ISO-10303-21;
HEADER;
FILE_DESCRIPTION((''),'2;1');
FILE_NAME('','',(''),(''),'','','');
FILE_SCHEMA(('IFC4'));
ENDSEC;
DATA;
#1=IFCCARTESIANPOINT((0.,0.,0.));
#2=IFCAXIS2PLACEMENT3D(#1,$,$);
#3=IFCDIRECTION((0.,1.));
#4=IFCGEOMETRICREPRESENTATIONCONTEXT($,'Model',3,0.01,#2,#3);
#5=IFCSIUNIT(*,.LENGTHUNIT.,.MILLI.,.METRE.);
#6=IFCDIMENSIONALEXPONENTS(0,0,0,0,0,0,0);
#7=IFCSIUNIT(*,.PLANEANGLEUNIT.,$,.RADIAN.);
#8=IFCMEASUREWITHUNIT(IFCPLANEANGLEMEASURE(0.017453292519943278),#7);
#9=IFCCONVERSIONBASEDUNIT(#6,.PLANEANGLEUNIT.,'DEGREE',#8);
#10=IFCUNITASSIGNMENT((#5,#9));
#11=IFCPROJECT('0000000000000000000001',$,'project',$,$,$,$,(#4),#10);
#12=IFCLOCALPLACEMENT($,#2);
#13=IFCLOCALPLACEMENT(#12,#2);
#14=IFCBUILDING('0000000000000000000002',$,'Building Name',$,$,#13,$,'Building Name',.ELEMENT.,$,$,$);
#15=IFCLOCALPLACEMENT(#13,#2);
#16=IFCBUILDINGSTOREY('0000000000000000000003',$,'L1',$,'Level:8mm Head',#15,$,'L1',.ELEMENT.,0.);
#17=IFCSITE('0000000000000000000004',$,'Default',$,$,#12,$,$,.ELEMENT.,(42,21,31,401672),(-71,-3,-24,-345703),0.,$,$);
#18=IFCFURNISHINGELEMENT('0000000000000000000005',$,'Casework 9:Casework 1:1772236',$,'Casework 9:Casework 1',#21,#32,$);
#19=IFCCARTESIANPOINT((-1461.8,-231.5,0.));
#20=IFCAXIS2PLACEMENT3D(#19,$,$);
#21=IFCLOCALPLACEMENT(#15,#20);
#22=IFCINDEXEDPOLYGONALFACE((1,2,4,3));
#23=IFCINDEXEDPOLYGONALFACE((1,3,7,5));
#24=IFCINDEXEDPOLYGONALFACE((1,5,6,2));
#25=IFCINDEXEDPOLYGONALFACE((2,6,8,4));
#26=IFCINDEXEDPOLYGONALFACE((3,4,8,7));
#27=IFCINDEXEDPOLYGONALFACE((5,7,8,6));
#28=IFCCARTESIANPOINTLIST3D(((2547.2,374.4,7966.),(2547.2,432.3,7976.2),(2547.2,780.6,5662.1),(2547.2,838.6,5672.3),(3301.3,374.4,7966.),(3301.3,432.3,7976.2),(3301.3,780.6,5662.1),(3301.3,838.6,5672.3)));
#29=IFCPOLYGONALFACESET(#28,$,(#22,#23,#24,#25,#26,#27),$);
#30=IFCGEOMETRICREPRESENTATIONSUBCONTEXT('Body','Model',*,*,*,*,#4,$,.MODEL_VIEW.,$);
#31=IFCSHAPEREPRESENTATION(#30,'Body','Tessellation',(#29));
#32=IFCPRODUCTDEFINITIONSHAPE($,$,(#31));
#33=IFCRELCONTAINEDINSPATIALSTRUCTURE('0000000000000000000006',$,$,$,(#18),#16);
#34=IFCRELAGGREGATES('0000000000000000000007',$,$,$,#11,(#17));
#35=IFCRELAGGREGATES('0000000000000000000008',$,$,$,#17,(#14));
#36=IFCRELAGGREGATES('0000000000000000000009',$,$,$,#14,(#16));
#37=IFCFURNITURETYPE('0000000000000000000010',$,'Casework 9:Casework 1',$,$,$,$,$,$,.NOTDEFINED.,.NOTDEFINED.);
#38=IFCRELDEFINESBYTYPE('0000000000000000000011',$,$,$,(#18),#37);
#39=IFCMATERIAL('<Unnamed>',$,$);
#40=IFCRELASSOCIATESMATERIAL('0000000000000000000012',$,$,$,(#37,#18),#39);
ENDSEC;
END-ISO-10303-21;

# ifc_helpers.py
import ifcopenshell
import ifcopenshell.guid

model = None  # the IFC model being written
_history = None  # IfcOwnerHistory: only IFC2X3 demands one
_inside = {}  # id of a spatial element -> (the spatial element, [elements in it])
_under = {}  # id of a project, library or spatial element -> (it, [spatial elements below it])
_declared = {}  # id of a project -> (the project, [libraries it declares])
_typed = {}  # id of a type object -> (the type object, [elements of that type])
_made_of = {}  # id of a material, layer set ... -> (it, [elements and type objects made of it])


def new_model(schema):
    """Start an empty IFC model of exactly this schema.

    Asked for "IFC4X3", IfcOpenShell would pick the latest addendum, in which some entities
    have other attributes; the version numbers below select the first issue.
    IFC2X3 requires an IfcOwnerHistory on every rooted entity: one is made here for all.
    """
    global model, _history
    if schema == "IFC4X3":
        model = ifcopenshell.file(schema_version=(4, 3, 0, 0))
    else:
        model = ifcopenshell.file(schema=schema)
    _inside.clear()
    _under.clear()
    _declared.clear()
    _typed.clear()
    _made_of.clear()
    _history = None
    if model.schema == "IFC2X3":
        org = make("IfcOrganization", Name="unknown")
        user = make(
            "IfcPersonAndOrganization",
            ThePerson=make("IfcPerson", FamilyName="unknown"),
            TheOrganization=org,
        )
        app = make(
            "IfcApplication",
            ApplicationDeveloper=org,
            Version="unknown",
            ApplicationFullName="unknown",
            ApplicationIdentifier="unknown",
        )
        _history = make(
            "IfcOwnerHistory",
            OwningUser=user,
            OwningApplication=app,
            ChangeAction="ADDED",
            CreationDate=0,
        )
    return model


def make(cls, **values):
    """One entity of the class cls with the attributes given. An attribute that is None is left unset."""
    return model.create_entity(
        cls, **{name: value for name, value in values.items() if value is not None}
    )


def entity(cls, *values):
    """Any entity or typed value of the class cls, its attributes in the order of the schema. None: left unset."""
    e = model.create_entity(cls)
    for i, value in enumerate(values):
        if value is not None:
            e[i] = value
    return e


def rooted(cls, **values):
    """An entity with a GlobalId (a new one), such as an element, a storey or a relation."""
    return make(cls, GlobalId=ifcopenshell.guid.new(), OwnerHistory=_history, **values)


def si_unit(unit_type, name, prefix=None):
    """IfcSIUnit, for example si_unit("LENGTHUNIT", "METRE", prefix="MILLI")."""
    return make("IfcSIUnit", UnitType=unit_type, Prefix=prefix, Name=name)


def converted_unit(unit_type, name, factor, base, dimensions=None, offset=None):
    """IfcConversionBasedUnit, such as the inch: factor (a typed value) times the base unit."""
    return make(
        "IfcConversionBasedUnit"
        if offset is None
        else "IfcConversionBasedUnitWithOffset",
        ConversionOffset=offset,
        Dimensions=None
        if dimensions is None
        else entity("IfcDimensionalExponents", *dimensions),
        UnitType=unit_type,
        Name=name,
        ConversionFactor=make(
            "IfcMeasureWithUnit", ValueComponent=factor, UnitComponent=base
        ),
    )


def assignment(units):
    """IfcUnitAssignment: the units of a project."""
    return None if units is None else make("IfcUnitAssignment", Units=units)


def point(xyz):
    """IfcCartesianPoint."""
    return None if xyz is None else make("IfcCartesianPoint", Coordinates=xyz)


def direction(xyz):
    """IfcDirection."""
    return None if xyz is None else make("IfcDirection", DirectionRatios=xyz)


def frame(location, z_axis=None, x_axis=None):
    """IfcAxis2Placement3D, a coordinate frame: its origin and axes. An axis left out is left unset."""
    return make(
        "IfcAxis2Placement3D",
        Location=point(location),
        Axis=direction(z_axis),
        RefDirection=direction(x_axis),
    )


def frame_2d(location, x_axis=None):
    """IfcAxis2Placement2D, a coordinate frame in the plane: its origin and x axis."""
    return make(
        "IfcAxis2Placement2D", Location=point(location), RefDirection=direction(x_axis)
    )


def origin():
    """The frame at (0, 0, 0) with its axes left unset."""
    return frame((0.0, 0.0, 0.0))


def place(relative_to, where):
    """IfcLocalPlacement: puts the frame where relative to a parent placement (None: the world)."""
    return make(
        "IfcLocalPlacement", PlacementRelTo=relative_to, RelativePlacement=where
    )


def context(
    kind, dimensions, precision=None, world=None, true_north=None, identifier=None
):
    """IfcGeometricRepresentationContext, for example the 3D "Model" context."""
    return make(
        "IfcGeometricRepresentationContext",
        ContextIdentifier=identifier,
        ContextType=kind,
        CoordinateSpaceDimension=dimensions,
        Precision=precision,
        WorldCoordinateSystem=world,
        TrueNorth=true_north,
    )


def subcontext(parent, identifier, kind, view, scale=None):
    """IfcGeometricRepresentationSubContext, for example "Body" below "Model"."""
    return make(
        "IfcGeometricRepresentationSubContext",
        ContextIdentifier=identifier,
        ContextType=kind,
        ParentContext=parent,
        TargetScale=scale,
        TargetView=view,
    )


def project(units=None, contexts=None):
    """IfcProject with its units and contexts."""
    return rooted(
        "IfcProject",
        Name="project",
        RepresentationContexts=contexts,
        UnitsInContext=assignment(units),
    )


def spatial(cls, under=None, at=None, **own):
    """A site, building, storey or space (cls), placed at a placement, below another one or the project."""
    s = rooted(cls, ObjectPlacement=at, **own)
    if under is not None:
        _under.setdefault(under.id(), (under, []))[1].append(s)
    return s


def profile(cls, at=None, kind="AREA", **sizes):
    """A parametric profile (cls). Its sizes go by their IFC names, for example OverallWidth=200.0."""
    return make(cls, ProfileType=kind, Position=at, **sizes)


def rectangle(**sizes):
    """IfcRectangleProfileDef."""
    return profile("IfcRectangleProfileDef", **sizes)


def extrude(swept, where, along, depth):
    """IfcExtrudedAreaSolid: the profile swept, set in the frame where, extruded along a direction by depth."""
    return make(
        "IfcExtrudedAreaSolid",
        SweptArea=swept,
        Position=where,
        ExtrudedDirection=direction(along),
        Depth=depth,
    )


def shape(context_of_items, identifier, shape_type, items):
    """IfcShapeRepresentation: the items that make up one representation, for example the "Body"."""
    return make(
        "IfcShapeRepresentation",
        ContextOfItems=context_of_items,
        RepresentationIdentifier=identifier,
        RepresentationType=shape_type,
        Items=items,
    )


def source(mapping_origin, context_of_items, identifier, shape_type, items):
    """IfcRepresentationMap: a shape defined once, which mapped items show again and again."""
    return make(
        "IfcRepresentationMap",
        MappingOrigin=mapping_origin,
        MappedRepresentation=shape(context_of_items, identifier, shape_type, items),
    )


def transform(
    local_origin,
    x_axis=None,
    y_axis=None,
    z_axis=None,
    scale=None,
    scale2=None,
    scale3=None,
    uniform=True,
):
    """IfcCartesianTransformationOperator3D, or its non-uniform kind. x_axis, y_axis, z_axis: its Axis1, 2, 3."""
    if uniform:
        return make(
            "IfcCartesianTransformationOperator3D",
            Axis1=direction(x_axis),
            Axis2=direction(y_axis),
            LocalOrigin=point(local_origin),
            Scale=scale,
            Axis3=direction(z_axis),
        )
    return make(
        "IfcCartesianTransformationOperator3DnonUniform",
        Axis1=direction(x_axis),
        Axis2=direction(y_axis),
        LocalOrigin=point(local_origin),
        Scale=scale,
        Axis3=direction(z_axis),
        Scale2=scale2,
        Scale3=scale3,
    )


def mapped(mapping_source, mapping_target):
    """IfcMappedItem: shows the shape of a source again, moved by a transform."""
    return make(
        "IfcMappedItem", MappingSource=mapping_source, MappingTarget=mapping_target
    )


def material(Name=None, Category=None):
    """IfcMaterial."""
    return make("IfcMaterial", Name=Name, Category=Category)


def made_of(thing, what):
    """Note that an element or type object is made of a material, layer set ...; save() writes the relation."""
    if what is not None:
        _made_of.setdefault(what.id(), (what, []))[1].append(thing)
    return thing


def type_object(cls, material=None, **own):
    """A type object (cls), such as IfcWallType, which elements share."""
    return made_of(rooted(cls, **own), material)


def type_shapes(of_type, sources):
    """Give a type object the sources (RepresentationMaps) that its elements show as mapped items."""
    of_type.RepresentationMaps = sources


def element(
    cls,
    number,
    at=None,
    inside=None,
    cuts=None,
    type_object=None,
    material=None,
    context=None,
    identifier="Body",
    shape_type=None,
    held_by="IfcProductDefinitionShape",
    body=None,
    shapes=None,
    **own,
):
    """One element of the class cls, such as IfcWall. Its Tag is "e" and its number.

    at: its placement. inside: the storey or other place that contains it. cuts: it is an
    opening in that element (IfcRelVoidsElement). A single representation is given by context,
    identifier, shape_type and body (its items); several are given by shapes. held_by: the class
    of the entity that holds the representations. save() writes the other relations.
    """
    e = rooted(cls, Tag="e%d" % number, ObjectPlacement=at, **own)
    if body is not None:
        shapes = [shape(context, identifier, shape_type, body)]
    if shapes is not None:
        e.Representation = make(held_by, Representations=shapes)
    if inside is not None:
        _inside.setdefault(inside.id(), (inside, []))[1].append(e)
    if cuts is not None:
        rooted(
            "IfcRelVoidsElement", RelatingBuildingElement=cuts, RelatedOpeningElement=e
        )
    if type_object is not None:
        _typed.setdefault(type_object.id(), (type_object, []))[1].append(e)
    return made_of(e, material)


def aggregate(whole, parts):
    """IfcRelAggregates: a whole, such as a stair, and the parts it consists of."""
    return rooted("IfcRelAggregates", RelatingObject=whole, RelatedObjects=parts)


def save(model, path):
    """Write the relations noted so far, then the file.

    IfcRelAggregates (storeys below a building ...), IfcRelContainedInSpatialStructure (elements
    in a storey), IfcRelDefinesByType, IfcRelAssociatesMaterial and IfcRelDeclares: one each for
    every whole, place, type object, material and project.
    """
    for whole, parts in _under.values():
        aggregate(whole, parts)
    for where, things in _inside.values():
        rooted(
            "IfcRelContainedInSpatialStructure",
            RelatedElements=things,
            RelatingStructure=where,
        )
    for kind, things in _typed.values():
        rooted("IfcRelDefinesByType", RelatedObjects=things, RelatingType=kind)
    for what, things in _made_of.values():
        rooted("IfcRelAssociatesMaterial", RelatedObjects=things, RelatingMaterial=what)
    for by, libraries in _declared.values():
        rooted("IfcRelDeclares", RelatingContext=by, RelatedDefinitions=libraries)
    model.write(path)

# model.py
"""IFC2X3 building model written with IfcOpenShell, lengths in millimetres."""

from ifc_helpers import new_model, entity, si_unit, converted_unit, direction, frame, frame_2d, origin, place, context, subcontext, project, spatial, rectangle, extrude, source, transform, mapped, material, type_object, type_shapes, element, save


model = new_model("IFC2X3")

# Units and contexts
model_context = context("Model", 3, precision=0.01, world=origin(), true_north=direction((0.0, 1.0)))
body_context = subcontext(model_context, "Body", "Model", "MODEL_VIEW")
ifc_project = project(units=[si_unit("LENGTHUNIT", "METRE", prefix="MILLI"), converted_unit("PLANEANGLEUNIT", "DEGREE", entity("IfcPlaneAngleMeasure", 0.017453292519943278), si_unit("PLANEANGLEUNIT", "RADIAN"), dimensions=[0, 0, 0, 0, 0, 0, 0])], contexts=[model_context])

# Site, building, storey
site_placement = place(None, origin())
site = spatial("IfcSite", under=ifc_project, at=site_placement, Name="Default", CompositionType="ELEMENT", RefLatitude=(42, 21, 31, 401672), RefLongitude=(-71, -3, -24, -345703), RefElevation=0.0)
building_placement = place(site_placement, origin())
building = spatial("IfcBuilding", under=site, at=building_placement, Name="Building Name", LongName="Building Name", CompositionType="ELEMENT")
storey_placement = place(building_placement, origin())
storey = spatial("IfcBuildingStorey", under=building, at=storey_placement, Name="L1", ObjectType="Level:8mm Head", LongName="L1", CompositionType="ELEMENT", Elevation=0.0)

# Shared definitions
ifc_material_1 = material(Name="<Unnamed>")

# Furnishing element
furniture_type_1 = type_object("IfcFurnitureType", Name="Casework 9:Casework 1", AssemblyPlace="NOTDEFINED", material=ifc_material_1)
shared_shape_1 = source(origin(), body_context, "Body", "SweptSolid", [
    extrude(rectangle(XDim=58.9, YDim=754.1, at=frame_2d((0.0, 0.0), x_axis=(1.0, 0.0))), frame((2924.3, 809.6, 5667.2), z_axis=(0.0, -0.173648, 0.984808), x_axis=(0.0, -0.984808, -0.173648)), (0.0, 0.0, 1.0), 2339.4),
])
type_shapes(furniture_type_1, [shared_shape_1])
furnishing_1_placement = place(storey_placement, frame((-1461.8, -231.5, 0.0)))
element("IfcFurnishingElement", 1, at=furnishing_1_placement, inside=storey, type_object=furniture_type_1, material=ifc_material_1, Name="Casework 9:Casework 1:1772236", ObjectType="Casework 9:Casework 1", context=body_context, shape_type="MappedRepresentation", body=[
    mapped(shared_shape_1, transform((0.0, 0.0, 0.0), scale=1.0)),
])

save(model, "model.ifc")
